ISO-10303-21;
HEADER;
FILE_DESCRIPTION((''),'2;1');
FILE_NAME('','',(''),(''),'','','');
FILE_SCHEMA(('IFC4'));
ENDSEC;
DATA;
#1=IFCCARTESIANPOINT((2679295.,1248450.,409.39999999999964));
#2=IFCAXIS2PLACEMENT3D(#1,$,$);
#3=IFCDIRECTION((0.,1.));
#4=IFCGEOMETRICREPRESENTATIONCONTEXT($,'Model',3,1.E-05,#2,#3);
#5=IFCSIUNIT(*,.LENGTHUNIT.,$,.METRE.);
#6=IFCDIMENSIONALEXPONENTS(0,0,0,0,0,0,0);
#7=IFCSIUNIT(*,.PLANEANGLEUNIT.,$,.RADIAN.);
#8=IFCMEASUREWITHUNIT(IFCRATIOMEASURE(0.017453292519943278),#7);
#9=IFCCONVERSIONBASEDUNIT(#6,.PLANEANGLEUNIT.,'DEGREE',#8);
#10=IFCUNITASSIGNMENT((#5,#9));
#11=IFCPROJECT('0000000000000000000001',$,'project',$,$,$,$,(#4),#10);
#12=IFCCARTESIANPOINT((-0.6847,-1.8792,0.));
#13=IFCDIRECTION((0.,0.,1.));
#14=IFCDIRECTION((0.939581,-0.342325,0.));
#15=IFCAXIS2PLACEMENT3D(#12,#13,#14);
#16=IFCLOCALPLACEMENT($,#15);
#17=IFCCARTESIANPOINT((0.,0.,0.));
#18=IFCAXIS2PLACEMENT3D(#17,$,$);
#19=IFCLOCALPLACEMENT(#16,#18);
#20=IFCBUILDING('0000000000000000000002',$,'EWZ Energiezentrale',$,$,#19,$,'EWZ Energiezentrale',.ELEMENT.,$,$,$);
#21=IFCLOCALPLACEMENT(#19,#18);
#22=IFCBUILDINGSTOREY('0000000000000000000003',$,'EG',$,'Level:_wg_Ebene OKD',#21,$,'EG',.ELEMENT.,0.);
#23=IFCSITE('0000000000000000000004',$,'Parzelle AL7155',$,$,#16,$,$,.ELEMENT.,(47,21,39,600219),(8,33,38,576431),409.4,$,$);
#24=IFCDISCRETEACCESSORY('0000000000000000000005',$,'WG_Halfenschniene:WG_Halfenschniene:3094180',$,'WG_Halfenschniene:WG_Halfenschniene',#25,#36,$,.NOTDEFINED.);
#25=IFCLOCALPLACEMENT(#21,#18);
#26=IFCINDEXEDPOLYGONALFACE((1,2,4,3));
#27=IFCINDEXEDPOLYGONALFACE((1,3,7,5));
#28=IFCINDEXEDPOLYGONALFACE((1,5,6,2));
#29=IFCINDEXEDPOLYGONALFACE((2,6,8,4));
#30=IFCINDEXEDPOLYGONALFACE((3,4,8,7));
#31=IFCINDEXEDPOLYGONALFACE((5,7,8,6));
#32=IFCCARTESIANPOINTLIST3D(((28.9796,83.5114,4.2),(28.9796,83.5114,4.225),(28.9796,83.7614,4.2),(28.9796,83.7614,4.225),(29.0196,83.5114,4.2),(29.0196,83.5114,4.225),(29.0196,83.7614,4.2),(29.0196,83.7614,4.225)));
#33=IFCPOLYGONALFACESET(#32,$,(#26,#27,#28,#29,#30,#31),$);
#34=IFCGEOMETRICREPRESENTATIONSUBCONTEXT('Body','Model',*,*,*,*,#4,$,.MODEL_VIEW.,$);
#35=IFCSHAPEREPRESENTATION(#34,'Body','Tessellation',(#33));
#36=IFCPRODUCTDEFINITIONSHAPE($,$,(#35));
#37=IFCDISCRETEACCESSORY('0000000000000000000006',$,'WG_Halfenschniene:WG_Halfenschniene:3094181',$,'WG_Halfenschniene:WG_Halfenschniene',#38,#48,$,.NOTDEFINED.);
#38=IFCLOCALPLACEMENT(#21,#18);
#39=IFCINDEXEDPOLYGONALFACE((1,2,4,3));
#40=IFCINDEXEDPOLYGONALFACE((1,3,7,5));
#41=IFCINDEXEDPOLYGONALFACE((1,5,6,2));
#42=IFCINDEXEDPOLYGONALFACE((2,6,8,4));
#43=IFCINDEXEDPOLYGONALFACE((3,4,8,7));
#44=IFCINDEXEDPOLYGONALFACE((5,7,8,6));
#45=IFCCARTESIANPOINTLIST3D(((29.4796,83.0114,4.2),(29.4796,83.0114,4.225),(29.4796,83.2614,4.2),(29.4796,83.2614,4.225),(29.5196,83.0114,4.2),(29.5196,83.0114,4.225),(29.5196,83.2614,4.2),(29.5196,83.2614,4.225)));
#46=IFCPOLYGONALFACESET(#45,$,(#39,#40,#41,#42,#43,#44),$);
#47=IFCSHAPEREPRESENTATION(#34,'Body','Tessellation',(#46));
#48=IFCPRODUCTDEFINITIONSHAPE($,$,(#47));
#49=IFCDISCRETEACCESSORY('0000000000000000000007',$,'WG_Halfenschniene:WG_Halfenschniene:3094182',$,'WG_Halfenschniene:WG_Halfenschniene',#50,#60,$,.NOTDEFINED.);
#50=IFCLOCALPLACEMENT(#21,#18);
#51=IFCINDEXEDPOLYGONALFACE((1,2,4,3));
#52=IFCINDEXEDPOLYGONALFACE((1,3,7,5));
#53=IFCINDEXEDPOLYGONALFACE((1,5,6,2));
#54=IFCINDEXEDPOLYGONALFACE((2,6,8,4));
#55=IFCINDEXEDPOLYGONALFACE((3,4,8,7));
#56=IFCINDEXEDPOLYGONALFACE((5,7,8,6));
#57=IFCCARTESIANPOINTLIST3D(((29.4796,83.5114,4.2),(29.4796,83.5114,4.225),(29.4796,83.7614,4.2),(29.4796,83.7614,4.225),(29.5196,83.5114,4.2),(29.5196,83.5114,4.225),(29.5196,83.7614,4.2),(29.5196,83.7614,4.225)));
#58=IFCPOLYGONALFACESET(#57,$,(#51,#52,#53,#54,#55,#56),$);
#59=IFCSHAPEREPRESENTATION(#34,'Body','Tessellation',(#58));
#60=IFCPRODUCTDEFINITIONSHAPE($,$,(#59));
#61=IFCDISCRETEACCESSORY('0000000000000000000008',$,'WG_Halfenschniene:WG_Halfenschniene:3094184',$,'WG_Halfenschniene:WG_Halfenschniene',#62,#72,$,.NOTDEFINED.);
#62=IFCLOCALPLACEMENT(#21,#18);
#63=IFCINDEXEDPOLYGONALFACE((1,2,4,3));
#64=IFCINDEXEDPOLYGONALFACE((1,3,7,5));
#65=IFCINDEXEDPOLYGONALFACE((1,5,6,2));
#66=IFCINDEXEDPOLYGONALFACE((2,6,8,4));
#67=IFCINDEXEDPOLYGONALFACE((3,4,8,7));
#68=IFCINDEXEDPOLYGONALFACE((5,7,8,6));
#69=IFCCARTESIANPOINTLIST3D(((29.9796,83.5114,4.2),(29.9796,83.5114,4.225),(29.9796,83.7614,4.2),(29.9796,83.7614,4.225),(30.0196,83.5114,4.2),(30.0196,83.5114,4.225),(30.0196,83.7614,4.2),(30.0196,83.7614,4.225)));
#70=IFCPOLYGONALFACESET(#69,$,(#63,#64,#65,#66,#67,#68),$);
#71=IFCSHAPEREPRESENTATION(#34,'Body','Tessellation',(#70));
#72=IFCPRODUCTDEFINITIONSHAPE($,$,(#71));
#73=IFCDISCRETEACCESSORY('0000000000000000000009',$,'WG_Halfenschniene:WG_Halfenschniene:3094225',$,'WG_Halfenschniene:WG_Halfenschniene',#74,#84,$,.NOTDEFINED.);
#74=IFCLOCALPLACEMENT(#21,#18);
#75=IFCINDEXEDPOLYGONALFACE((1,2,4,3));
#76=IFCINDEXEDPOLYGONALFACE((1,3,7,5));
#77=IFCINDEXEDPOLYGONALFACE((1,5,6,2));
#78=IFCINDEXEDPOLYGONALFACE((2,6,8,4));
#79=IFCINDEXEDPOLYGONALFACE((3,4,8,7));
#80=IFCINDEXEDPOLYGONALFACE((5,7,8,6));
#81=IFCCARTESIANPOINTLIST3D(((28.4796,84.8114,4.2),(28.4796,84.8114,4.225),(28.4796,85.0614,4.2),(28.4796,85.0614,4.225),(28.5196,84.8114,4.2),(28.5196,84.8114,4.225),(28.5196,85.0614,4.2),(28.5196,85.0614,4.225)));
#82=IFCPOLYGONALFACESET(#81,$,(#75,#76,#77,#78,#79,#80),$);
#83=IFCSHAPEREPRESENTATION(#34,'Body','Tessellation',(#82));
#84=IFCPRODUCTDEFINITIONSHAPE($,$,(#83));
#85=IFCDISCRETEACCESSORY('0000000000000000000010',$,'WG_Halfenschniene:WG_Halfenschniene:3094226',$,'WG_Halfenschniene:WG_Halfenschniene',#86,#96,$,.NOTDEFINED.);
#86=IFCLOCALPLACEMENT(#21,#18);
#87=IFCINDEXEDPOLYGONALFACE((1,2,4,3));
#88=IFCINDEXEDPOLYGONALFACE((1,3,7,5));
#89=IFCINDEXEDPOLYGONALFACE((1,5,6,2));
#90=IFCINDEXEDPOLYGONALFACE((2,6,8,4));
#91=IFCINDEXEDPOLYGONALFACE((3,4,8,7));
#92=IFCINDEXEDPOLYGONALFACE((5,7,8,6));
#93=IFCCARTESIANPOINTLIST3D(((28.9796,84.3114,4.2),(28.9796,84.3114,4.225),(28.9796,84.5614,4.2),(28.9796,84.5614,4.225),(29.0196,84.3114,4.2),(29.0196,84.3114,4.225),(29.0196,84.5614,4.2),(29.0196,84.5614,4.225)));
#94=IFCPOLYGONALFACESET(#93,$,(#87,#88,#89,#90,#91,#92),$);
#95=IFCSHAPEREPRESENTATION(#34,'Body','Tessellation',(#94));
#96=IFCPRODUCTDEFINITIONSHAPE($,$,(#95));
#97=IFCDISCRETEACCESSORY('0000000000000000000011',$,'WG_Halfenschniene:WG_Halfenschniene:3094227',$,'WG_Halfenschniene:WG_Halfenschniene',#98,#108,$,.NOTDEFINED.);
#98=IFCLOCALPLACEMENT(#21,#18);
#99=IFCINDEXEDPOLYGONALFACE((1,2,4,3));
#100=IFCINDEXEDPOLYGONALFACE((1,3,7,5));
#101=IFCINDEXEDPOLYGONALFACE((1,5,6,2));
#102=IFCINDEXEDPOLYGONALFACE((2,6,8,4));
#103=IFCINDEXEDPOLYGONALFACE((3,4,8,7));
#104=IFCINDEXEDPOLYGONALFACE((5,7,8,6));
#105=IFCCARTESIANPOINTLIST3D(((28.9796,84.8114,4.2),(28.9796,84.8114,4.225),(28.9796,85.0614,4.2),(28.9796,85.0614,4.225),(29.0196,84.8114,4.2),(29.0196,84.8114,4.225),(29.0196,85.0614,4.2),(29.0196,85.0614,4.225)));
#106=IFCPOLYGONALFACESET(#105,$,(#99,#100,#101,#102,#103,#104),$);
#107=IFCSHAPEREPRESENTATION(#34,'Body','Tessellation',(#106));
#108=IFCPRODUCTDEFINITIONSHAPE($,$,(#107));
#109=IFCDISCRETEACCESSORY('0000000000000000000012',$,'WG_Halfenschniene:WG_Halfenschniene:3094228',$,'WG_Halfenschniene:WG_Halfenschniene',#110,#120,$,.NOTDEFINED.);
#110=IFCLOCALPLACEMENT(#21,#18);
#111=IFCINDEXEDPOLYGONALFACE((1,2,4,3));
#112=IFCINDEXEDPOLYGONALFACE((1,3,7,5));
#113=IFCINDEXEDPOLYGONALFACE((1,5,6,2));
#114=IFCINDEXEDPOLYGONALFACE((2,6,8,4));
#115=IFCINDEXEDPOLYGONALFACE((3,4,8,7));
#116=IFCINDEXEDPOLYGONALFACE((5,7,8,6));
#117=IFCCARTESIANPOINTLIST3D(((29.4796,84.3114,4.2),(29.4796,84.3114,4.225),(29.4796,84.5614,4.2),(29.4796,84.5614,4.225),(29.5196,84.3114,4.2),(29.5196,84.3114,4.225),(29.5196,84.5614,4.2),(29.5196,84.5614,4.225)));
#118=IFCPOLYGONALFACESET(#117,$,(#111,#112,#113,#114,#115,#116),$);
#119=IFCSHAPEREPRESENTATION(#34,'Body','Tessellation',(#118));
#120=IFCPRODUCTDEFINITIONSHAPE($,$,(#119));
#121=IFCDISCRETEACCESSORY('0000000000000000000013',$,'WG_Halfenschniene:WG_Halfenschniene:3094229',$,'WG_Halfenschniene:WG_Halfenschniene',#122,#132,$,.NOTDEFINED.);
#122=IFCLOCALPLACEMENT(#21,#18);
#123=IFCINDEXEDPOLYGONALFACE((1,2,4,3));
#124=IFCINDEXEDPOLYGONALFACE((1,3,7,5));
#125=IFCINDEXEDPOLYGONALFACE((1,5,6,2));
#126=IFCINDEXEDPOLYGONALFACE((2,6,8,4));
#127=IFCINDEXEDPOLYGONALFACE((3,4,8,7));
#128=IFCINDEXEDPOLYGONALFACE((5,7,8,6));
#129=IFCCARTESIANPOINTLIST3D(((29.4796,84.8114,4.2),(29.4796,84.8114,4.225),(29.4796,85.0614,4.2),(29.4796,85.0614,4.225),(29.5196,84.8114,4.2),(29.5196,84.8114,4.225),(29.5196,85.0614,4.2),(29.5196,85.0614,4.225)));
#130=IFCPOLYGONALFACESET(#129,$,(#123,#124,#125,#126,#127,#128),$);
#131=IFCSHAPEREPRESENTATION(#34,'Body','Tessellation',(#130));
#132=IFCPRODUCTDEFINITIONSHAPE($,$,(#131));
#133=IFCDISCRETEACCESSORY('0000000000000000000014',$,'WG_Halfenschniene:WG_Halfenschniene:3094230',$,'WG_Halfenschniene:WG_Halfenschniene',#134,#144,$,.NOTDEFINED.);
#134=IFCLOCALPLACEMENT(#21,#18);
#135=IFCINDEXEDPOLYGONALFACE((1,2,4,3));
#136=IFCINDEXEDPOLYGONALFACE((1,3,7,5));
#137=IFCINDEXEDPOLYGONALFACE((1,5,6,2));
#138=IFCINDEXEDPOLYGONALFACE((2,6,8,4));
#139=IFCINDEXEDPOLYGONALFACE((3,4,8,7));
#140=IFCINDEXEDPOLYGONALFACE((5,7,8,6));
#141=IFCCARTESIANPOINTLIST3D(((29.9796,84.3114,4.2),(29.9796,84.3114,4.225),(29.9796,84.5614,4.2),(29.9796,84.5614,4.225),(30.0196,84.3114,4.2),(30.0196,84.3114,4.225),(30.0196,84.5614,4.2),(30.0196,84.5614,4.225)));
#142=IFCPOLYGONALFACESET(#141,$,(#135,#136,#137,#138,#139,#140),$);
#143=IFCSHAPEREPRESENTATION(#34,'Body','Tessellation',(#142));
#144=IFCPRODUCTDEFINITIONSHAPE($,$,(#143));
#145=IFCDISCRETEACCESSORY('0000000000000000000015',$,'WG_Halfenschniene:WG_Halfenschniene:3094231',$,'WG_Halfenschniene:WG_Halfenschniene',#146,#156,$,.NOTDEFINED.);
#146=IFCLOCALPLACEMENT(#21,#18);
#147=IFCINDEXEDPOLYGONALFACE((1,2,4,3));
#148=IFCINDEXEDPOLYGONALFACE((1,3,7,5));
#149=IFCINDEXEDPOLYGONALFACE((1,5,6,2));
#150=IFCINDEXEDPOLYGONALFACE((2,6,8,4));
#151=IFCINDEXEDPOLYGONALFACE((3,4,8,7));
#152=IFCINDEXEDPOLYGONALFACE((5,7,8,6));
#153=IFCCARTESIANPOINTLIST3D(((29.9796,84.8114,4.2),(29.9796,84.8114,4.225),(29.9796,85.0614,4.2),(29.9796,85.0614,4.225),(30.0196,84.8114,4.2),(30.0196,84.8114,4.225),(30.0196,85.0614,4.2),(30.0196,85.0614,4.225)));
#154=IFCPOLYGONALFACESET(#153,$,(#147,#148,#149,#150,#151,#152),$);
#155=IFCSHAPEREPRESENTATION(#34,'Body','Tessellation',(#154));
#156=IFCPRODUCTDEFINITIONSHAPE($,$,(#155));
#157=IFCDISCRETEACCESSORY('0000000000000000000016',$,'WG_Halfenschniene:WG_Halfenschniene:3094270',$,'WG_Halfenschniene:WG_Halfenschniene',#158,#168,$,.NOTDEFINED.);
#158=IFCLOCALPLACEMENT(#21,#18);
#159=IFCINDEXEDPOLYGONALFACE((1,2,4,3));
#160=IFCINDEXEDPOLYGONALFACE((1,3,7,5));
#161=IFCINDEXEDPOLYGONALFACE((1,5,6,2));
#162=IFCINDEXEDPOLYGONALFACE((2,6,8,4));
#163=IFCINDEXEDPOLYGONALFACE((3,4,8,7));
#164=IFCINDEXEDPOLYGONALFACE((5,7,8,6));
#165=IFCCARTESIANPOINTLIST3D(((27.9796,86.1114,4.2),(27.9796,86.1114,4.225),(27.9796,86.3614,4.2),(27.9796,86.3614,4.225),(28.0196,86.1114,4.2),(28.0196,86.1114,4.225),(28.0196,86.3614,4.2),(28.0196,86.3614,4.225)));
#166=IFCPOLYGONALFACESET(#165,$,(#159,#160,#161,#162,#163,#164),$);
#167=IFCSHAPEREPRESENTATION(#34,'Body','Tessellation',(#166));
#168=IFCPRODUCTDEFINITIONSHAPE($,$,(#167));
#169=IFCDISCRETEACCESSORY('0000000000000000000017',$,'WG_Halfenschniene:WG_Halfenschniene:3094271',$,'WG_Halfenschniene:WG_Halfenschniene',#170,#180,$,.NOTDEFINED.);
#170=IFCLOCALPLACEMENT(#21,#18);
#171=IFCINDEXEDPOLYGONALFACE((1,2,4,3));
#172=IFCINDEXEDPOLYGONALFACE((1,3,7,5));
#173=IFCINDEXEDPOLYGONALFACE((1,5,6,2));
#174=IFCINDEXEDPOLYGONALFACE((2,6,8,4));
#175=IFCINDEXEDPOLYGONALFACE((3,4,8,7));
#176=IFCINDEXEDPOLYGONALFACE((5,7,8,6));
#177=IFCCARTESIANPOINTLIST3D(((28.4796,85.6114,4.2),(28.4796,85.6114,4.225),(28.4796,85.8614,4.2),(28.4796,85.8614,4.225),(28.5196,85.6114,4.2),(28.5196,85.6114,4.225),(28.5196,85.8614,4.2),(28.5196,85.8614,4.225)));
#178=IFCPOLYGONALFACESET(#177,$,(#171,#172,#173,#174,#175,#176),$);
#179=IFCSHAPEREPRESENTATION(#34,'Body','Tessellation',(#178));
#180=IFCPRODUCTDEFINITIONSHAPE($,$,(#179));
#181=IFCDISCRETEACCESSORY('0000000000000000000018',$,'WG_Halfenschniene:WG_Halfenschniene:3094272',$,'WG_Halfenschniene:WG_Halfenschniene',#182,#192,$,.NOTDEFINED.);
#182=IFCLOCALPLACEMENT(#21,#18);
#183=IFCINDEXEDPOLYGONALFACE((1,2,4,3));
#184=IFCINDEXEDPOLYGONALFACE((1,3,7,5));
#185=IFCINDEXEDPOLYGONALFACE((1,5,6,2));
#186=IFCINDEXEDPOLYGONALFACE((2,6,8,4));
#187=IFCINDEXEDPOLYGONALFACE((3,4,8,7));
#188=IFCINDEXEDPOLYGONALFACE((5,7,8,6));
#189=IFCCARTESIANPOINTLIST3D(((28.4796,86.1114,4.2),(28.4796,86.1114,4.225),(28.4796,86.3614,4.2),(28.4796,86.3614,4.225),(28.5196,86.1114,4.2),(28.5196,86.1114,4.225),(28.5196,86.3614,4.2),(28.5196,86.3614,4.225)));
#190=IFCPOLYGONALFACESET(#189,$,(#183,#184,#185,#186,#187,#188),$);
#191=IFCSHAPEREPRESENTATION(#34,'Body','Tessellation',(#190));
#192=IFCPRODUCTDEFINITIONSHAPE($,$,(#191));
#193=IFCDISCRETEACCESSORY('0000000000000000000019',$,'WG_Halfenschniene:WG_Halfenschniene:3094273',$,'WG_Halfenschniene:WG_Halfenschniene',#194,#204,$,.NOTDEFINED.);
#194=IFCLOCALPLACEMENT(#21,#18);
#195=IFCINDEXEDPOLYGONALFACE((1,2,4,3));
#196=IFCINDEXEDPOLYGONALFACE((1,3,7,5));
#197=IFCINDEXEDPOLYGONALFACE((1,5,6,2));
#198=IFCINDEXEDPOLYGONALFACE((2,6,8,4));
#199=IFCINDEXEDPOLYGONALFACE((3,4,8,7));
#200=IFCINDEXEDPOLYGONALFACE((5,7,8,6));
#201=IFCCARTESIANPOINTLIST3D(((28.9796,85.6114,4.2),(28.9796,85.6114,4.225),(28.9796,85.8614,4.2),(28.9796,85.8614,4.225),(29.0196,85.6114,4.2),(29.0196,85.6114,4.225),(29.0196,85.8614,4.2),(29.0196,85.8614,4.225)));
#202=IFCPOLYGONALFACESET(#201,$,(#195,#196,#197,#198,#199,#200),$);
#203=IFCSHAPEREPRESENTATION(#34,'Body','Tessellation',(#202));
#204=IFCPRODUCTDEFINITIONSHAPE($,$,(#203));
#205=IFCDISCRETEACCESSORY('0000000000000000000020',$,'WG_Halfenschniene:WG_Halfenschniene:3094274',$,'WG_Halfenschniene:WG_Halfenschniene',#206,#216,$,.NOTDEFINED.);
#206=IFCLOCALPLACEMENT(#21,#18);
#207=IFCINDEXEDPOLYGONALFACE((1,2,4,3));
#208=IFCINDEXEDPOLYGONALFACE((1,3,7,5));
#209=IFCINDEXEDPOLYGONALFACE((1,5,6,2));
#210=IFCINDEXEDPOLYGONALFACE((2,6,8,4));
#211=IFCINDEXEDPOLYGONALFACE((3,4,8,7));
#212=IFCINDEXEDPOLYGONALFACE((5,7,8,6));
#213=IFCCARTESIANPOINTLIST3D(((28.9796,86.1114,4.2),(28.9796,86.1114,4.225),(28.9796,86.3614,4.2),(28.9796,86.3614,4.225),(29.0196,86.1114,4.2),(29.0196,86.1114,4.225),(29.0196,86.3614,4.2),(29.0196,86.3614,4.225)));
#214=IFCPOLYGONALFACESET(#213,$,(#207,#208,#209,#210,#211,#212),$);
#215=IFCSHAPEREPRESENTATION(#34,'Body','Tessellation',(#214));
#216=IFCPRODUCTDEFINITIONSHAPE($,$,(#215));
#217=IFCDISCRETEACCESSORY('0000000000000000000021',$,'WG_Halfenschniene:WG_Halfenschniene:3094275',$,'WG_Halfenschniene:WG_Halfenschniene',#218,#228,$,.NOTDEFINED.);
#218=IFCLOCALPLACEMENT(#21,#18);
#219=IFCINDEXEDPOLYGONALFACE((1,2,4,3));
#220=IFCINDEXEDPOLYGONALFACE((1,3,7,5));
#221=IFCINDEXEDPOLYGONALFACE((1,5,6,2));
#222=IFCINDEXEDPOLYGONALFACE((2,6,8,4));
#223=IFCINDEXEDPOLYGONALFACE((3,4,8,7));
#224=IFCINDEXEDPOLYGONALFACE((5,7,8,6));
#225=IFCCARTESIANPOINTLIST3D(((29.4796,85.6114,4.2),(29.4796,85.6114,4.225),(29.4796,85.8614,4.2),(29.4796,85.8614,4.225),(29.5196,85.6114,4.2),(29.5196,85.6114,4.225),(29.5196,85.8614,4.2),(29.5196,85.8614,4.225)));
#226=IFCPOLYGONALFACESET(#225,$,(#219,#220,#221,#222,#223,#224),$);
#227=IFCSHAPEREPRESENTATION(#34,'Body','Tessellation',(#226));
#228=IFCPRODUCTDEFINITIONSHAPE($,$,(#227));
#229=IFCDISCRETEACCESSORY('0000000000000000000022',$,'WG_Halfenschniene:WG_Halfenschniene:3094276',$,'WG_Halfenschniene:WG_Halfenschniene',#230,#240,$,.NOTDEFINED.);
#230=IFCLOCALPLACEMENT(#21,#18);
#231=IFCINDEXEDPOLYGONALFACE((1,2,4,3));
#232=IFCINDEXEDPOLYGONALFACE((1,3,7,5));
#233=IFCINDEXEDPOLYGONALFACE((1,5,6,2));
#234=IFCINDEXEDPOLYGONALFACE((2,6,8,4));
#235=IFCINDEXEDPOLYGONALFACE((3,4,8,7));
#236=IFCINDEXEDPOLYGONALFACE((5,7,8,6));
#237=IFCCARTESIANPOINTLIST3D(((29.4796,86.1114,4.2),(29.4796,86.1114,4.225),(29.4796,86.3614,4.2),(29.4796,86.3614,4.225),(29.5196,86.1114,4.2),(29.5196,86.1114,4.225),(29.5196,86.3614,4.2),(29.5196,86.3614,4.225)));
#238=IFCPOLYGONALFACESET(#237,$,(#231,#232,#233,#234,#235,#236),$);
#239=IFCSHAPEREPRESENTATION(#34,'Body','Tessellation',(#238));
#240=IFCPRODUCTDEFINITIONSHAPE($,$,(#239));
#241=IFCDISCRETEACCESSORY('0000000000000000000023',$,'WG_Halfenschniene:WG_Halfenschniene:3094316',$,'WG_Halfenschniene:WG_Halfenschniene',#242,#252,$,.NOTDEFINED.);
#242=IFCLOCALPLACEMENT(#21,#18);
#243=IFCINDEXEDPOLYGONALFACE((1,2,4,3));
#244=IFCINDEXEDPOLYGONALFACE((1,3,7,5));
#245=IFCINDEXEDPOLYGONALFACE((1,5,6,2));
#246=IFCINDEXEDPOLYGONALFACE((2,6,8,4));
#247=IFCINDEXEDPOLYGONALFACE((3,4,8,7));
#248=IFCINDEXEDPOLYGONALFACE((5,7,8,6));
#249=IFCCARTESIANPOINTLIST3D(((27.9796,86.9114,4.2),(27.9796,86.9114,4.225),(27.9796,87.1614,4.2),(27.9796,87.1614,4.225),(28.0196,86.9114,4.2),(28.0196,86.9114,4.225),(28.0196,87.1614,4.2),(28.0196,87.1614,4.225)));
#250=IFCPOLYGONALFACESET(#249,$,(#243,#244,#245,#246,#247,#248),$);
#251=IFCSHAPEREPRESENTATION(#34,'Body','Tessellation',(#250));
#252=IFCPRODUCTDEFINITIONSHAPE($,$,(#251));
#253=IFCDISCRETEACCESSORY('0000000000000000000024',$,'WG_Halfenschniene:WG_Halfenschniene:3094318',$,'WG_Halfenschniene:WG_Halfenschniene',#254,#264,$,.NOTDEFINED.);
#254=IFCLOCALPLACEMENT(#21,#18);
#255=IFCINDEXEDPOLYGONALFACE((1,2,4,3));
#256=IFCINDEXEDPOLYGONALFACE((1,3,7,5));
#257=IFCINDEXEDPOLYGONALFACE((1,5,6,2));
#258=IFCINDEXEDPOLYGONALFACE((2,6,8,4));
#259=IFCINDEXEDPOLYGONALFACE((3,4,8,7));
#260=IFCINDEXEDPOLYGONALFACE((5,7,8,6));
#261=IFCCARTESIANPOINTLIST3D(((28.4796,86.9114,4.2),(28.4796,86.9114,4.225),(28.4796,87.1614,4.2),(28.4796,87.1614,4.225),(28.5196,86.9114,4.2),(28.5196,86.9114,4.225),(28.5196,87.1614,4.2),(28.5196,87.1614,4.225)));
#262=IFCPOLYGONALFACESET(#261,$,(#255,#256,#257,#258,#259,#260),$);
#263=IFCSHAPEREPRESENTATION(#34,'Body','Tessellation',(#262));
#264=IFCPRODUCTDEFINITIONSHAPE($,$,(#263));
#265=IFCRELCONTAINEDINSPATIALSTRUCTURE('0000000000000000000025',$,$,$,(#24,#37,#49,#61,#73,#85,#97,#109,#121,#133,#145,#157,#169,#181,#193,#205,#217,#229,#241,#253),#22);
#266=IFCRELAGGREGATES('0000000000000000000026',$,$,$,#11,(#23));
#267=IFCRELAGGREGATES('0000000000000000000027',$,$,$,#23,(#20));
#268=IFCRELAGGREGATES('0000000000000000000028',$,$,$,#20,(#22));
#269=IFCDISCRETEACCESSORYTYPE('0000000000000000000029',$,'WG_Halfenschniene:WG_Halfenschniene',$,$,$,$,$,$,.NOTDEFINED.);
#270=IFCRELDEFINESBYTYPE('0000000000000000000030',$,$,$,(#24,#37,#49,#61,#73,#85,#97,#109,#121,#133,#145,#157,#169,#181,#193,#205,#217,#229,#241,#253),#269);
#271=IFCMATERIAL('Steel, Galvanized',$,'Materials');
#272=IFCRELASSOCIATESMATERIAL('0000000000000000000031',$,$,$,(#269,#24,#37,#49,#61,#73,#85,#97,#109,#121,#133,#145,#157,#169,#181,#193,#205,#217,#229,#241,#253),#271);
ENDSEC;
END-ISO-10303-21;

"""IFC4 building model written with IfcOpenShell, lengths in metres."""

from ifc_helpers import new_model, entity, si_unit, converted_unit, direction, frame, origin, place, context, subcontext, project, spatial, indexed_curve, outline, extrude, source, transform, mapped, material, type_object, element, save


model = new_model("IFC4")

# Units and contexts
model_context = context("Model", 3, precision=1e-05, world=frame((2679295.0, 1248450.0, 409.39999999999964)), true_north=direction((0.0, 1.0)))
body_context = subcontext(model_context, "Body", "Model", "MODEL_VIEW")
ifc_project = project(units=[si_unit("LENGTHUNIT", "METRE"), converted_unit("PLANEANGLEUNIT", "DEGREE", entity("IfcRatioMeasure", 0.017453292519943278), si_unit("PLANEANGLEUNIT", "RADIAN"), dimensions=[0, 0, 0, 0, 0, 0, 0])], contexts=[model_context])

# Site, building, storey
site_placement = place(None, frame((-0.6847, -1.8792, 0.0), z_axis=(0.0, 0.0, 1.0), x_axis=(0.939581, -0.342325, 0.0)))
site = spatial("IfcSite", under=ifc_project, at=site_placement, Name="Parzelle AL7155", CompositionType="ELEMENT", RefLatitude=(47, 21, 39, 600219), RefLongitude=(8, 33, 38, 576431), RefElevation=409.4)
building_placement = place(site_placement, origin())
building = spatial("IfcBuilding", under=site, at=building_placement, Name="EWZ Energiezentrale", LongName="EWZ Energiezentrale", CompositionType="ELEMENT")
storey_placement = place(building_placement, origin())
storey = spatial("IfcBuildingStorey", under=building, at=storey_placement, Name="EG", ObjectType="Level:_wg_Ebene OKD", LongName="EG", CompositionType="ELEMENT", Elevation=0.0)

# Discrete accessories
ifc_material = material(Name="Steel, Galvanized", Category="Materials")
discrete_accessory_type = type_object("IfcDiscreteAccessoryType", Name="WG_Halfenschniene:WG_Halfenschniene", PredefinedType="NOTDEFINED", material=ifc_material)
shared_shape = source(origin(), body_context, "Body", "SweptSolid", [
    extrude(outline(indexed_curve([(-0.125, -0.02), (0.125, -0.02), (0.125, 0.02), (-0.125, 0.02), (-0.125, -0.02)], self_intersect=False)), frame((0.125, 0.0, -0.0125)), (0.0, 0.0, 1.0), 0.025),
])
for number, where, z_axis, x_axis, name in (
    (1, (28.9996, 83.5114, 4.2125), (0.0, 0.0, -1.0), (0.0, 1.0, 0.0), "WG_Halfenschniene:WG_Halfenschniene:3094180"),
    (2, (29.4996, 83.0114, 4.2125), (0.0, 0.0, -1.0), (0.0, 1.0, 0.0), "WG_Halfenschniene:WG_Halfenschniene:3094181"),
    (3, (29.4996, 83.5114, 4.2125), (0.0, 0.0, -1.0), (0.0, 1.0, 0.0), "WG_Halfenschniene:WG_Halfenschniene:3094182"),
    (4, (29.9996, 83.5114, 4.2125), (0.0, 0.0, -1.0), (0.0, 1.0, 0.0), "WG_Halfenschniene:WG_Halfenschniene:3094184"),
    (5, (28.4996, 84.8114, 4.2125), (0.0, 0.0, -1.0), (0.0, 1.0, 0.0), "WG_Halfenschniene:WG_Halfenschniene:3094225"),
    (6, (28.9996, 84.3114, 4.2125), (0.0, 0.0, -1.0), (0.0, 1.0, 0.0), "WG_Halfenschniene:WG_Halfenschniene:3094226"),
    (7, (28.9996, 84.8114, 4.2125), (0.0, 0.0, -1.0), (0.0, 1.0, 0.0), "WG_Halfenschniene:WG_Halfenschniene:3094227"),
    (8, (29.4996, 84.3114, 4.2125), (0.0, 0.0, -1.0), (0.0, 1.0, 0.0), "WG_Halfenschniene:WG_Halfenschniene:3094228"),
    (9, (29.4996, 84.8114, 4.2125), (0.0, 0.0, -1.0), (0.0, 1.0, 0.0), "WG_Halfenschniene:WG_Halfenschniene:3094229"),
    (10, (29.9996, 84.3114, 4.2125), (0.0, 0.0, -1.0), (0.0, 1.0, 0.0), "WG_Halfenschniene:WG_Halfenschniene:3094230"),
    (11, (29.9996, 84.8114, 4.2125), (0.0, 0.0, -1.0), (0.0, 1.0, 0.0), "WG_Halfenschniene:WG_Halfenschniene:3094231"),
    (12, (27.9996, 86.1114, 4.2125), (0.0, 0.0, -1.0), (0.0, 1.0, 0.0), "WG_Halfenschniene:WG_Halfenschniene:3094270"),
    (13, (28.4996, 85.6114, 4.2125), (0.0, 0.0, -1.0), (0.0, 1.0, 0.0), "WG_Halfenschniene:WG_Halfenschniene:3094271"),
    (14, (28.4996, 86.1114, 4.2125), (0.0, 0.0, -1.0), (0.0, 1.0, 0.0), "WG_Halfenschniene:WG_Halfenschniene:3094272"),
    (15, (28.9996, 85.6114, 4.2125), (0.0, 0.0, -1.0), (0.0, 1.0, 0.0), "WG_Halfenschniene:WG_Halfenschniene:3094273"),
    (16, (28.9996, 86.1114, 4.2125), (0.0, 0.0, -1.0), (0.0, 1.0, 0.0), "WG_Halfenschniene:WG_Halfenschniene:3094274"),
    (17, (29.4996, 85.6114, 4.2125), (0.0, 0.0, -1.0), (0.0, 1.0, 0.0), "WG_Halfenschniene:WG_Halfenschniene:3094275"),
    (18, (29.4996, 86.1114, 4.2125), (0.0, 0.0, -1.0), (0.0, 1.0, 0.0), "WG_Halfenschniene:WG_Halfenschniene:3094276"),
    (19, (27.9996, 86.9114, 4.2125), (0.0, 0.0, -1.0), (0.0, 1.0, 0.0), "WG_Halfenschniene:WG_Halfenschniene:3094316"),
    (20, (28.4996, 86.9114, 4.2125), (0.0, 0.0, -1.0), (0.0, 1.0, 0.0), "WG_Halfenschniene:WG_Halfenschniene:3094318"),
):
    element("IfcDiscreteAccessory", number, at=place(storey_placement, frame(where, z_axis=z_axis, x_axis=x_axis)), inside=storey, type_object=discrete_accessory_type, material=ifc_material, Name=name, ObjectType="WG_Halfenschniene:WG_Halfenschniene", PredefinedType="NOTDEFINED", context=body_context, shape_type="MappedRepresentation", body=[
        mapped(shared_shape, transform((0.0, 0.0, 0.0), scale=1.0)),
    ])

save(model, "model.ifc")
